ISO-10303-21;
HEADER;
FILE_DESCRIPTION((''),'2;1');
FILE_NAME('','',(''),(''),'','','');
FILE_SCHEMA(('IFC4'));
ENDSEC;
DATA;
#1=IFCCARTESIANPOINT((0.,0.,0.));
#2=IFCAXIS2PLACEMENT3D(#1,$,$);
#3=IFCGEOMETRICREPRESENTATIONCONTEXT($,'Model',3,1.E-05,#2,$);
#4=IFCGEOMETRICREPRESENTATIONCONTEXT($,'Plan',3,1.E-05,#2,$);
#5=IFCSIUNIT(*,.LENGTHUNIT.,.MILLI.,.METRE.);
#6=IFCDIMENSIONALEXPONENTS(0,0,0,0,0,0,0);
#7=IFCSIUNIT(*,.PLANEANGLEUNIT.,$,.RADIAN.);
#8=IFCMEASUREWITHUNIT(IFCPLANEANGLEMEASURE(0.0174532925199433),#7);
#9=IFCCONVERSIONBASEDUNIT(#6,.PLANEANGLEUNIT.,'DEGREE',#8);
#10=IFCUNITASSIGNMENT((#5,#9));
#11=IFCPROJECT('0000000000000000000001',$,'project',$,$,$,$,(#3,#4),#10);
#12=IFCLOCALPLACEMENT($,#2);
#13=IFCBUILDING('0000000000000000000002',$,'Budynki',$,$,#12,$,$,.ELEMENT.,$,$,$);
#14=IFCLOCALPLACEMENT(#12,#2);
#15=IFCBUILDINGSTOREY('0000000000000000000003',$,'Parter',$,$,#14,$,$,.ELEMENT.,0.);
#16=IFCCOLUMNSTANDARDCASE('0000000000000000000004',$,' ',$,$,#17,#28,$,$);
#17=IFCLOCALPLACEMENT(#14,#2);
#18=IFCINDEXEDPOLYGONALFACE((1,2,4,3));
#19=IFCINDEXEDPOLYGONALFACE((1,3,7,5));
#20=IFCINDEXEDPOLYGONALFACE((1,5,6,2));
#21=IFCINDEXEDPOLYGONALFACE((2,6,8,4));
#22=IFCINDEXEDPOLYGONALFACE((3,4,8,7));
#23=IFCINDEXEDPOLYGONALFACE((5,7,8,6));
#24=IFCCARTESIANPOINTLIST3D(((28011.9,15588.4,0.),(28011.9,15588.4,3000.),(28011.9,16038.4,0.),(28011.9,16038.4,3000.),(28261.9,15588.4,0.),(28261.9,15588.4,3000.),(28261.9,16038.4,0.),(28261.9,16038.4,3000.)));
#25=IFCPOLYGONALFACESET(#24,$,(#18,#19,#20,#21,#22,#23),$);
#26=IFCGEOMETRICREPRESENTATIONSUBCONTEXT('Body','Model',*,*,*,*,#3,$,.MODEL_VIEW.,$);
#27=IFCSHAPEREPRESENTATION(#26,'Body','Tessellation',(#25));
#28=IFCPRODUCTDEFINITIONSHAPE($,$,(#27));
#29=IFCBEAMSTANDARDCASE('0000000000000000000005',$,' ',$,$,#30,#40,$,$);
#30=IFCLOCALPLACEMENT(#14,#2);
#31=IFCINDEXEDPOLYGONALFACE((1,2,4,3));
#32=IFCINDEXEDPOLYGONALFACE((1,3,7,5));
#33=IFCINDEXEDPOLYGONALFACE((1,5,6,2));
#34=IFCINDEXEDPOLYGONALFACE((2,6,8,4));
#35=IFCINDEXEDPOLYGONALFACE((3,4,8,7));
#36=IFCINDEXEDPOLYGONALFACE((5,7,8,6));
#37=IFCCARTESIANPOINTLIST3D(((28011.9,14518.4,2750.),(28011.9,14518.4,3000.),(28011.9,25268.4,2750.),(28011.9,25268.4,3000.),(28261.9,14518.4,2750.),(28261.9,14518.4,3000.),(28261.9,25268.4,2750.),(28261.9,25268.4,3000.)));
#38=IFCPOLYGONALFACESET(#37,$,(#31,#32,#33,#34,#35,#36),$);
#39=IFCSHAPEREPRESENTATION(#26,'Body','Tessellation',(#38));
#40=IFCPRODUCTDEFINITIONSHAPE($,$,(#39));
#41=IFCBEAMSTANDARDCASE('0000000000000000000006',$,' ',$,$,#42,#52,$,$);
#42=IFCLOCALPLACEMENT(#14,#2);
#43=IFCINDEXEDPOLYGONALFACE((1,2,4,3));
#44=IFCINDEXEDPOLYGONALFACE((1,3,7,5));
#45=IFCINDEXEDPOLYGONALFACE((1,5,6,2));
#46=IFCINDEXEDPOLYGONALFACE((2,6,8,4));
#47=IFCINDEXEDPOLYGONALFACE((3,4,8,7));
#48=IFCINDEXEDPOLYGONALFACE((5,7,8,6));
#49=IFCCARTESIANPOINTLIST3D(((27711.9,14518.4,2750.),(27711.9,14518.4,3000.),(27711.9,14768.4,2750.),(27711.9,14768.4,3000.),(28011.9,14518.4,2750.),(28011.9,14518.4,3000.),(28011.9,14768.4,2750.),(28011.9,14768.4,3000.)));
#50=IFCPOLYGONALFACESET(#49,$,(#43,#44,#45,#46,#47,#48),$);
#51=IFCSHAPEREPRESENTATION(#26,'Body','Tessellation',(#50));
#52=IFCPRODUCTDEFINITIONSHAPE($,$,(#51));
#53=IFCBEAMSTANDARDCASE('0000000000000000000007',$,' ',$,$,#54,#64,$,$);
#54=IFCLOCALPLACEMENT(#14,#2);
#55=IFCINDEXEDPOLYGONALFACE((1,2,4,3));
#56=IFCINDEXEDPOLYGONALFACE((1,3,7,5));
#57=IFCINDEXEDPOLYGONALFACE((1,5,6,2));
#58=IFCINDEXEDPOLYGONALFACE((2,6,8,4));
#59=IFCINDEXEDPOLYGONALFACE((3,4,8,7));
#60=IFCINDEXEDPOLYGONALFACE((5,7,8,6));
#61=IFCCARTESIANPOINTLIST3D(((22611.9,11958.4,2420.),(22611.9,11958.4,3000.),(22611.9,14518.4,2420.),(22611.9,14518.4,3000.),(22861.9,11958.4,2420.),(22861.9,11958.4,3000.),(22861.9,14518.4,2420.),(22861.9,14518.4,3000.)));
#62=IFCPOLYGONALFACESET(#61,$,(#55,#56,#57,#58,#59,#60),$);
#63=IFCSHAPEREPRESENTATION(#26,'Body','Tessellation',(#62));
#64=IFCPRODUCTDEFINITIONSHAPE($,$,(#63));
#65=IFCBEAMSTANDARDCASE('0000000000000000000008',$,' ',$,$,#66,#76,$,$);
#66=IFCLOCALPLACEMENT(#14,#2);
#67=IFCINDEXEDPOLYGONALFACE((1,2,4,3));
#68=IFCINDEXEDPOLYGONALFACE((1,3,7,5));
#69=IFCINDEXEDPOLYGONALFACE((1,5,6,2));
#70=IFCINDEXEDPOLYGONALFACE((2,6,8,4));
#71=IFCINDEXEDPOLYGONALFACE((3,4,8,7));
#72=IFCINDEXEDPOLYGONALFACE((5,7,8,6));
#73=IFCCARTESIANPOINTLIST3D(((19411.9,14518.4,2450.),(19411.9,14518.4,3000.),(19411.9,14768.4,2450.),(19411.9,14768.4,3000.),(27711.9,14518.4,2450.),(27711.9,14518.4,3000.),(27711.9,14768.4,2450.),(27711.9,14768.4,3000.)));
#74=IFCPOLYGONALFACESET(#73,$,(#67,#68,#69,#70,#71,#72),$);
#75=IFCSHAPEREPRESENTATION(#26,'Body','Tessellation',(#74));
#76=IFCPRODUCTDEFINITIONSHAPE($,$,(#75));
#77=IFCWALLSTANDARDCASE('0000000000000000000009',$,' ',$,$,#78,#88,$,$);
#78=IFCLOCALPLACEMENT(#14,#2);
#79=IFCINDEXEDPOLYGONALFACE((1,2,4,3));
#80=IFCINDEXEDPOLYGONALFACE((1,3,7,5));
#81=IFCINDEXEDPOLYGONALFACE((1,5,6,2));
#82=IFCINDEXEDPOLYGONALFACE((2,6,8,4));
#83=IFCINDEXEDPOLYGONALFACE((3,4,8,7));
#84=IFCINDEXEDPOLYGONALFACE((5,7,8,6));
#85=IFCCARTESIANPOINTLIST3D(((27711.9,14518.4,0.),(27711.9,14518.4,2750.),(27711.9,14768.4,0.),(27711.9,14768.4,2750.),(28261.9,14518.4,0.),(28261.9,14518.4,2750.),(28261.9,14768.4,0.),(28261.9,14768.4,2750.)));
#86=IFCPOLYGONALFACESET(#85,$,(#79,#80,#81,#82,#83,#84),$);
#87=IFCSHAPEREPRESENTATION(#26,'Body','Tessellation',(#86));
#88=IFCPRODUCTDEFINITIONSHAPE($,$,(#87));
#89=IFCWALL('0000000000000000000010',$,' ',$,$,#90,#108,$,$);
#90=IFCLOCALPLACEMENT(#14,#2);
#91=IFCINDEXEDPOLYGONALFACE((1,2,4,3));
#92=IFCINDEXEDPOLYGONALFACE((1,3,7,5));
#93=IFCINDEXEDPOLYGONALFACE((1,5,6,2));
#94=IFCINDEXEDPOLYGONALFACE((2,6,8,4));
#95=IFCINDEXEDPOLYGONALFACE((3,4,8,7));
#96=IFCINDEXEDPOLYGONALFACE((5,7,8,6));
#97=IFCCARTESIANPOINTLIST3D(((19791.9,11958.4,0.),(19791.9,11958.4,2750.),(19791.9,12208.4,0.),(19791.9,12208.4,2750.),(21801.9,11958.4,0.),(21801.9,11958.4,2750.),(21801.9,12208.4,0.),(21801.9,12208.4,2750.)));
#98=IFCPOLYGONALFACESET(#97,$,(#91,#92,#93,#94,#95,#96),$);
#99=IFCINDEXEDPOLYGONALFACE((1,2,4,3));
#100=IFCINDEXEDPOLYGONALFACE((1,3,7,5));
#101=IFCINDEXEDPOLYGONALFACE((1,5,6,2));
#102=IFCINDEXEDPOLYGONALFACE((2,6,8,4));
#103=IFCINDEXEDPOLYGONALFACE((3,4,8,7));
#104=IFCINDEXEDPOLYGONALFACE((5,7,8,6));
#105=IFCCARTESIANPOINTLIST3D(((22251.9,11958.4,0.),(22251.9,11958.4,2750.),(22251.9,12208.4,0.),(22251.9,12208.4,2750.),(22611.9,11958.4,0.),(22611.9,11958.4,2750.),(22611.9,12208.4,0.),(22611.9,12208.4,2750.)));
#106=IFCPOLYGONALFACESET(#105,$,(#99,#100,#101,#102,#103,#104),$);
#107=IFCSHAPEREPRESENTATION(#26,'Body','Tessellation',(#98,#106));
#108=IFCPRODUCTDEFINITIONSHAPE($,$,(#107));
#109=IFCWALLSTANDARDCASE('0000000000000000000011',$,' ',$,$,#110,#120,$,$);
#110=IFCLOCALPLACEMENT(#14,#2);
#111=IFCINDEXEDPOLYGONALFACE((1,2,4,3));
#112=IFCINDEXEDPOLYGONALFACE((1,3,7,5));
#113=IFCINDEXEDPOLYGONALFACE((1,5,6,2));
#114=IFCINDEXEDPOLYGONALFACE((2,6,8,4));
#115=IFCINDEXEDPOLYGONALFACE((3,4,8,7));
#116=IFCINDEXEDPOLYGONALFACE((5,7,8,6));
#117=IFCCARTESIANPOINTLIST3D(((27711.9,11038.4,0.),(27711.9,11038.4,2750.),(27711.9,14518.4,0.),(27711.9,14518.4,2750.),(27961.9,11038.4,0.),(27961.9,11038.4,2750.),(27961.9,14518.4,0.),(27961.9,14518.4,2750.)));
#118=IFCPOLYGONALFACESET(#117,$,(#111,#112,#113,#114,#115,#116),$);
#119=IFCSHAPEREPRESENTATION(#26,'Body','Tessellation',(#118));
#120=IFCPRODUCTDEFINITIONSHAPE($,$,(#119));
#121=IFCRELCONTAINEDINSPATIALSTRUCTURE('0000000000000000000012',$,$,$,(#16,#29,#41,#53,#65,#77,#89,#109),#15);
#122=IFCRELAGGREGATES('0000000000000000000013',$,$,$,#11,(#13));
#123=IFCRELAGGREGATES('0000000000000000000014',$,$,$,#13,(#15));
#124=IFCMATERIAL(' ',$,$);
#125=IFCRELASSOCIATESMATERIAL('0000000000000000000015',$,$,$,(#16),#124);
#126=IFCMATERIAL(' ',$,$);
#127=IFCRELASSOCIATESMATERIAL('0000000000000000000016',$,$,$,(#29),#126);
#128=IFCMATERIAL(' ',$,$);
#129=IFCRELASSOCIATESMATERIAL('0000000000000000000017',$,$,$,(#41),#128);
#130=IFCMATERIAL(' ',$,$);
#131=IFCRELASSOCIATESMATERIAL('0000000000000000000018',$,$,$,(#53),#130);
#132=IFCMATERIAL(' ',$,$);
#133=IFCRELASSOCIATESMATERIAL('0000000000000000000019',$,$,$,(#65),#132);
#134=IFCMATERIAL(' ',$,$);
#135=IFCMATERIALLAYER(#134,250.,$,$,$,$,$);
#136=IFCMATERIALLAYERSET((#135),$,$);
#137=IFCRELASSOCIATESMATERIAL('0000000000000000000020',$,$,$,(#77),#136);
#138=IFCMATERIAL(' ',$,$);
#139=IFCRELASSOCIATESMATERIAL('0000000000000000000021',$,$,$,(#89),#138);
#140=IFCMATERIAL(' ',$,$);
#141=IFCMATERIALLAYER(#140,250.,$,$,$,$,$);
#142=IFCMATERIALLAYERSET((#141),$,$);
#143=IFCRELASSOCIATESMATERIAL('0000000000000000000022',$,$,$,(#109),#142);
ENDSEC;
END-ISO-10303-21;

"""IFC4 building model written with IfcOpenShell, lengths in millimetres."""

from ifc_helpers import new_model, entity, si_unit, converted_unit, frame, frame_2d, origin, origin_with_axes, place, context, subcontext, project, spatial, rectangle, extrude, material, layer, layer_set, layer_usage, material_profile, profile_set, profile_usage, element, save


model = new_model("IFC4")

# Units and contexts
model_context = context("Model", 3, precision=1e-05, world=origin())
plan_context = context("Plan", 3, precision=1e-05, world=origin())
body_context = subcontext(model_context, "Body", "Model", "MODEL_VIEW")
ifc_project = project(units=[si_unit("LENGTHUNIT", "METRE", prefix="MILLI"), converted_unit("PLANEANGLEUNIT", "DEGREE", entity("IfcPlaneAngleMeasure", 0.0174532925199433), si_unit("PLANEANGLEUNIT", "RADIAN"), dimensions=[0, 0, 0, 0, 0, 0, 0])], contexts=[model_context, plan_context])

# Building, storey
building_placement = place(None, origin())
building = spatial("IfcBuilding", under=ifc_project, at=building_placement, Name="Budynki", CompositionType="ELEMENT")
storey_placement = place(building_placement, origin())
storey = spatial("IfcBuildingStorey", under=building, at=storey_placement, Name="Parter", CompositionType="ELEMENT", Elevation=0.0)

# Column
ifc_material_1 = material(Name=" ")
ifc_material_profile_1 = material_profile(ifc_material_1, rectangle(XDim=450.0, YDim=250.0, at=frame_2d((-125.0, 225.0), x_axis=(0.0, 1.0))))
ifc_profile_set_1 = profile_set([ifc_material_profile_1])
ifc_profile_usage_1 = profile_usage(ifc_profile_set_1)
column_placement = place(storey_placement, frame((28011.9, 15588.4, 0.0)))
element("IfcColumnStandardCase", 1, at=column_placement, inside=storey, material=ifc_profile_usage_1, Name=" ", context=body_context, shape_type="SweptSolid", body=[
    extrude(rectangle(XDim=450.0, YDim=250.0, at=frame_2d((-125.0, 225.0), x_axis=(0.0, 1.0))), frame((250.0, 0.0, 0.0), z_axis=(0.0, 0.0, 1.0), x_axis=(1.0, 0.0, 0.0)), (0.0, 0.0, 1.0), 3000.0),
])

# Beams
ifc_material_2 = material(Name=" ")
ifc_material_profile_2 = material_profile(ifc_material_2, rectangle(XDim=250.0, YDim=250.0, at=frame_2d((125.0, -125.0), x_axis=(0.0, 1.0))))
ifc_profile_set_2 = profile_set([ifc_material_profile_2])
ifc_profile_usage_2 = profile_usage(ifc_profile_set_2)
beam_1_placement = place(storey_placement, frame((28261.9, 14518.4, 2750.0), z_axis=(0.0, 0.0, 1.0), x_axis=(0.0, 1.0, 0.0)))
element("IfcBeamStandardCase", 2, at=beam_1_placement, inside=storey, material=ifc_profile_usage_2, Name=" ", context=body_context, shape_type="SweptSolid", body=[
    extrude(rectangle(XDim=250.0, YDim=250.0, at=frame_2d((125.0, -125.0), x_axis=(0.0, 1.0))), frame((0.0, 0.0, 0.0), z_axis=(1.0, 0.0, 0.0), x_axis=(0.0, 0.0, 1.0)), (0.0, 0.0, 1.0), 10750.0),
])
ifc_material_3 = material(Name=" ")
ifc_material_profile_3 = material_profile(ifc_material_3, rectangle(XDim=250.0, YDim=250.0, at=frame_2d((125.0, -125.0), x_axis=(0.0, 1.0))))
ifc_profile_set_3 = profile_set([ifc_material_profile_3])
ifc_profile_usage_3 = profile_usage(ifc_profile_set_3)
beam_2_placement = place(storey_placement, frame((27711.9, 14518.4, 2750.0)))
element("IfcBeamStandardCase", 3, at=beam_2_placement, inside=storey, material=ifc_profile_usage_3, Name=" ", context=body_context, shape_type="SweptSolid", body=[
    extrude(rectangle(XDim=250.0, YDim=250.0, at=frame_2d((125.0, -125.0), x_axis=(0.0, 1.0))), frame((0.0, 0.0, 0.0), z_axis=(1.0, 0.0, 0.0), x_axis=(0.0, 0.0, 1.0)), (0.0, 0.0, 1.0), 300.0),
])
ifc_material_4 = material(Name=" ")
ifc_material_profile_4 = material_profile(ifc_material_4, rectangle(XDim=250.0, YDim=580.0, at=frame_2d((290.0, -125.0), x_axis=(0.0, 1.0))))
ifc_profile_set_4 = profile_set([ifc_material_profile_4])
ifc_profile_usage_4 = profile_usage(ifc_profile_set_4)
beam_3_placement = place(storey_placement, frame((22861.9, 11958.4, 2420.0), z_axis=(0.0, 0.0, 1.0), x_axis=(0.0, 1.0, 0.0)))
element("IfcBeamStandardCase", 4, at=beam_3_placement, inside=storey, material=ifc_profile_usage_4, Name=" ", context=body_context, shape_type="SweptSolid", body=[
    extrude(rectangle(XDim=250.0, YDim=580.0, at=frame_2d((290.0, -125.0), x_axis=(0.0, 1.0))), frame((0.0, 0.0, 0.0), z_axis=(1.0, 0.0, 0.0), x_axis=(0.0, 0.0, 1.0)), (0.0, 0.0, 1.0), 2560.0),
])
ifc_material_5 = material(Name=" ")
ifc_material_profile_5 = material_profile(ifc_material_5, rectangle(XDim=250.0, YDim=550.0, at=frame_2d((275.0, -125.0), x_axis=(0.0, 1.0))))
ifc_profile_set_5 = profile_set([ifc_material_profile_5])
ifc_profile_usage_5 = profile_usage(ifc_profile_set_5)
beam_4_placement = place(storey_placement, frame((27711.9, 14768.4, 2450.0), z_axis=(0.0, 0.0, 1.0), x_axis=(-1.0, 0.0, 0.0)))
element("IfcBeamStandardCase", 5, at=beam_4_placement, inside=storey, material=ifc_profile_usage_5, Name=" ", context=body_context, shape_type="SweptSolid", body=[
    extrude(rectangle(XDim=250.0, YDim=550.0, at=frame_2d((275.0, -125.0), x_axis=(0.0, 1.0))), frame((0.0, 0.0, 0.0), z_axis=(1.0, 0.0, 0.0), x_axis=(0.0, 0.0, 1.0)), (0.0, 0.0, 1.0), 8300.0),
])

# Walls
ifc_material_6 = material(Name=" ")
ifc_layer_1 = layer(ifc_material_6, 250.0)
ifc_layer_set_1 = layer_set([ifc_layer_1])
ifc_layer_usage_1 = layer_usage(ifc_layer_set_1, "AXIS2", "POSITIVE", 0.0)
wall_1_placement = place(storey_placement, frame((28261.9, 14768.4, 0.0), z_axis=(0.0, 0.0, 1.0), x_axis=(-1.0, 0.0, 0.0)))
element("IfcWallStandardCase", 6, at=wall_1_placement, inside=storey, material=ifc_layer_usage_1, Name=" ", context=body_context, shape_type="SweptSolid", body=[
    extrude(rectangle(XDim=550.0, YDim=250.0, at=frame_2d((275.0, 125.0), x_axis=(1.0, 0.0))), origin_with_axes(), (0.0, 0.0, 1.0), 2750.0),
])
ifc_material_7 = material(Name=" ")
wall_2_placement = place(storey_placement, frame((22611.9, 12208.4, 0.0), z_axis=(0.0, 0.0, 1.0), x_axis=(-1.0, 0.0, 0.0)))
element("IfcWall", 7, at=wall_2_placement, inside=storey, material=ifc_material_7, Name=" ", context=body_context, shape_type="SweptSolid", body=[
    extrude(rectangle(XDim=250.0, YDim=2010.0, at=frame_2d((-1005.0, 125.0), x_axis=(0.0, 1.0))), frame((2820.0, 0.0, 0.0), z_axis=(0.0, 0.0, 1.0), x_axis=(1.0, 0.0, 0.0)), (0.0, 0.0, 1.0), 2750.0),
    extrude(rectangle(XDim=250.0, YDim=360.0, at=frame_2d((-180.0, 125.0), x_axis=(0.0, 1.0))), frame((360.0, 0.0, 0.0), z_axis=(0.0, 0.0, 1.0), x_axis=(1.0, 0.0, 0.0)), (0.0, 0.0, 1.0), 2750.0),
])
ifc_material_8 = material(Name=" ")
ifc_layer_2 = layer(ifc_material_8, 250.0)
ifc_layer_set_2 = layer_set([ifc_layer_2])
ifc_layer_usage_2 = layer_usage(ifc_layer_set_2, "AXIS2", "POSITIVE", 0.0)
wall_3_placement = place(storey_placement, frame((27711.9, 14518.4, 0.0), z_axis=(0.0, 0.0, 1.0), x_axis=(0.0, -1.0, 0.0)))
element("IfcWallStandardCase", 8, at=wall_3_placement, inside=storey, material=ifc_layer_usage_2, Name=" ", context=body_context, shape_type="SweptSolid", body=[
    extrude(rectangle(XDim=3480.0, YDim=250.0, at=frame_2d((1740.0, 125.0), x_axis=(1.0, 0.0))), origin_with_axes(), (0.0, 0.0, 1.0), 2750.0),
])

save(model, "model.ifc")
